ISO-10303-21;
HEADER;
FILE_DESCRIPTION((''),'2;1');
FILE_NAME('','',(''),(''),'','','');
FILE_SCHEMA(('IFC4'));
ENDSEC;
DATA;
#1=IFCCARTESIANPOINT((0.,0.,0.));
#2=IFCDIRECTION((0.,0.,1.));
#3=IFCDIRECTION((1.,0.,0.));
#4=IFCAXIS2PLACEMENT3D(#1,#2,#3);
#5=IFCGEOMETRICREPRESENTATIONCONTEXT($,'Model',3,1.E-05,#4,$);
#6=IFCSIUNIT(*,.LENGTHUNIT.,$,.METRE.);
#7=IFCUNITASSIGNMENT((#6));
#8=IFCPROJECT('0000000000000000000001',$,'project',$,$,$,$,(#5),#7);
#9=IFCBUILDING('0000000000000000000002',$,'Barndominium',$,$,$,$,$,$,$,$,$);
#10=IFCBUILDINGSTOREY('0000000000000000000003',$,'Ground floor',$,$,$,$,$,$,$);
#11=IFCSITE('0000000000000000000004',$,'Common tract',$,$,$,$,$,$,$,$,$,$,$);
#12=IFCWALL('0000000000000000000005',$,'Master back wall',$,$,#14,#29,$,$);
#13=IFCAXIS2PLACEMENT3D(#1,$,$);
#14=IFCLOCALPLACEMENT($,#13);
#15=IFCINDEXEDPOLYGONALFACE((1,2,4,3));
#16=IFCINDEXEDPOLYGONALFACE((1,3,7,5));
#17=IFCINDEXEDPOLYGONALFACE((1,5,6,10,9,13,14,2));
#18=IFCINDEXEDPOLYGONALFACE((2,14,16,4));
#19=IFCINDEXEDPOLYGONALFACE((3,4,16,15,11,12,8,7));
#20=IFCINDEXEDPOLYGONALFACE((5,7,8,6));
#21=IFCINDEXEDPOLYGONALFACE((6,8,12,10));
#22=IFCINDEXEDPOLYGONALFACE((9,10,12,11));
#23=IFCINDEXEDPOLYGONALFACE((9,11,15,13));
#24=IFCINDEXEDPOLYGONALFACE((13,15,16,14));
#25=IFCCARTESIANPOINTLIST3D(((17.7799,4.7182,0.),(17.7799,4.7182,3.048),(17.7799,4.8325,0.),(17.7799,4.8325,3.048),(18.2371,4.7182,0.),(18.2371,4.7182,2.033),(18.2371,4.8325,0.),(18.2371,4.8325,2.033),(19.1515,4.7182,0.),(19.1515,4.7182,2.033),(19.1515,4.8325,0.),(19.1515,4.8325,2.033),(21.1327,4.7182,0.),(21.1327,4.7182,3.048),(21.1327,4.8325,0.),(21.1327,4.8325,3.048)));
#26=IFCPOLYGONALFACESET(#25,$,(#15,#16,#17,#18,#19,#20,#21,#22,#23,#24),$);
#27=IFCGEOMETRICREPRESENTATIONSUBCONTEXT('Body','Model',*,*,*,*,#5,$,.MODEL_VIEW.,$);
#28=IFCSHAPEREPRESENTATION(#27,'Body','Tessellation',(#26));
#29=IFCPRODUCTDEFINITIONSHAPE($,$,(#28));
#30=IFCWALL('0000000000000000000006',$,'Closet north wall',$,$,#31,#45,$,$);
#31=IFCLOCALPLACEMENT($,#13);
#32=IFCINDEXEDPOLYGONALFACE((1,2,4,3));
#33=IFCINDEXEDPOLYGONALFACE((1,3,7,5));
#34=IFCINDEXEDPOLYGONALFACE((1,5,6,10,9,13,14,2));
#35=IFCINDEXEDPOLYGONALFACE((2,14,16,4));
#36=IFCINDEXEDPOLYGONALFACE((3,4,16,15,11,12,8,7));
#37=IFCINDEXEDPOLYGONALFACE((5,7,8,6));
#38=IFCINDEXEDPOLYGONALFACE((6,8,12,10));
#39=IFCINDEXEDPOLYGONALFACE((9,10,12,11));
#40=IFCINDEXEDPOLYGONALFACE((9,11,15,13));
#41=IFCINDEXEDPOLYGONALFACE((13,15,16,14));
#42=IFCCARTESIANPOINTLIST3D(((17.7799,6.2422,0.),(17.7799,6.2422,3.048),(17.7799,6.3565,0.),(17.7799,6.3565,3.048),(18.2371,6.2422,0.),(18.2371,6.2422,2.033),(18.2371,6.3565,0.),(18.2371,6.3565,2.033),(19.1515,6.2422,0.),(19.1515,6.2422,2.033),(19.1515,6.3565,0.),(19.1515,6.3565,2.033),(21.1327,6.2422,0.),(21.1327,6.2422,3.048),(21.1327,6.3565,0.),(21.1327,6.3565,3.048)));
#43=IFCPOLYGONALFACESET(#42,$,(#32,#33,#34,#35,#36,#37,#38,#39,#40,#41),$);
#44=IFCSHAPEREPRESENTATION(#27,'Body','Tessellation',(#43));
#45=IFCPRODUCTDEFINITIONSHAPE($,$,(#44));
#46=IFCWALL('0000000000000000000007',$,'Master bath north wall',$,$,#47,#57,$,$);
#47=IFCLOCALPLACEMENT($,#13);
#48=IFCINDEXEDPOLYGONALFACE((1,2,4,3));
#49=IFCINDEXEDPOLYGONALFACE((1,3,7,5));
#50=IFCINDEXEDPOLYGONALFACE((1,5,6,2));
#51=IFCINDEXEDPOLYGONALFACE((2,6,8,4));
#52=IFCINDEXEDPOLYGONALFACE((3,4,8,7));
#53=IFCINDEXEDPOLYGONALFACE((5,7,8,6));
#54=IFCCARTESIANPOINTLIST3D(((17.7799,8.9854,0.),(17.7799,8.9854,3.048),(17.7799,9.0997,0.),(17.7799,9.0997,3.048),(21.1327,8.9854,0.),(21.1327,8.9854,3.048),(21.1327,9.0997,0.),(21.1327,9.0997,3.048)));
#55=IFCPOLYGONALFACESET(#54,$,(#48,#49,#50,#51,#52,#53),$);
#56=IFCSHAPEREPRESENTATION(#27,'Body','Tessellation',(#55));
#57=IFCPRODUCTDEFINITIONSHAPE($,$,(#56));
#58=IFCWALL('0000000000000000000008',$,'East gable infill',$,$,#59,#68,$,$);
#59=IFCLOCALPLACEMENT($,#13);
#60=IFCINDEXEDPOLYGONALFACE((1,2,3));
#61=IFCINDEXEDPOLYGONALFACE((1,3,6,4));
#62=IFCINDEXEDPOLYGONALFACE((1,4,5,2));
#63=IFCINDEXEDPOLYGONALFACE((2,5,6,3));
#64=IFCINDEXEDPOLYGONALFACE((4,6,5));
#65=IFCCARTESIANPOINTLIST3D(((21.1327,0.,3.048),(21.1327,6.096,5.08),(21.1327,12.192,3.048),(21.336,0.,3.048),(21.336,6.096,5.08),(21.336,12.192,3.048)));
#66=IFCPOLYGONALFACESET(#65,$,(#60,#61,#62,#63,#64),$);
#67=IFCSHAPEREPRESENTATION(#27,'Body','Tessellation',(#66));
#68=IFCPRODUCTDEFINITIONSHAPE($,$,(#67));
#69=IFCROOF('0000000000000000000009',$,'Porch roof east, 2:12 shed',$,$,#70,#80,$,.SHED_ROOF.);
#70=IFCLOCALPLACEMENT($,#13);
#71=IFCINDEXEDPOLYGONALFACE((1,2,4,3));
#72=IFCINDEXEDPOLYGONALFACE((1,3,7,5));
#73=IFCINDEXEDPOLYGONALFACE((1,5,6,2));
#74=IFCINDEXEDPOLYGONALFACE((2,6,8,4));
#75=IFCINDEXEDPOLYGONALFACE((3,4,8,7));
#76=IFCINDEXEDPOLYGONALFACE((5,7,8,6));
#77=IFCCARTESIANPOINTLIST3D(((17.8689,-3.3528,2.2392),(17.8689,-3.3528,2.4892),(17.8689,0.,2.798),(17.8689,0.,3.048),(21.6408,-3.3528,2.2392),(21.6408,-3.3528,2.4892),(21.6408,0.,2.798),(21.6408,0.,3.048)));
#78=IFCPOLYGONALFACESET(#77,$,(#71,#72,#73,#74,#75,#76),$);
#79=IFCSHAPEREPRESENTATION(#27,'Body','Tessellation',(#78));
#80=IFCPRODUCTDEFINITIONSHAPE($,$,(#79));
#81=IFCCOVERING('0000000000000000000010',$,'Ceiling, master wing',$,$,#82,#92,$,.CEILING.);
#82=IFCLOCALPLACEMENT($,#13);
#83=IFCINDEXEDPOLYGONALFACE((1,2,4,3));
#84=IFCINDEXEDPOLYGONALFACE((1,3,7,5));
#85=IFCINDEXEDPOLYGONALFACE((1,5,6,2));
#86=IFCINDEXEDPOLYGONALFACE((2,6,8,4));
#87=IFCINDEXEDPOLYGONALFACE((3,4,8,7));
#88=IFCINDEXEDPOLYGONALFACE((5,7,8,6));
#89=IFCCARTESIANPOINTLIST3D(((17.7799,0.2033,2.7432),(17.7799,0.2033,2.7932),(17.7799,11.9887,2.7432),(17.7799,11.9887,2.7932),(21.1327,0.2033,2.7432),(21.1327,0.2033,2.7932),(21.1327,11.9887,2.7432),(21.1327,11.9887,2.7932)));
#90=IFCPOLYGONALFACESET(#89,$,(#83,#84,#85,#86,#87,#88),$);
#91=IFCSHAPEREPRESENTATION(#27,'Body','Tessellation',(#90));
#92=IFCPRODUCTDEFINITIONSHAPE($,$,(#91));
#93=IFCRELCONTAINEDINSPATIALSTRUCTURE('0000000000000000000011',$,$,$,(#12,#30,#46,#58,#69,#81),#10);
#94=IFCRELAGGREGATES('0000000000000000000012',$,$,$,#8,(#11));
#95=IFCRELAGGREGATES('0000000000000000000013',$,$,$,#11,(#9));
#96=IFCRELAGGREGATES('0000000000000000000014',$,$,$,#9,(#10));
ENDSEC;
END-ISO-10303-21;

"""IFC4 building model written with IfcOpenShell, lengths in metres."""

from ifc_helpers import new_model, si_unit, frame, origin_with_axes, place, context, subcontext, project, spatial, polyline, indexed_curve, rectangle, outline, extrude, element, save


model = new_model("IFC4")

# Units and contexts
model_context = context("Model", 3, precision=1e-05, world=origin_with_axes())
body_context = subcontext(model_context, "Body", "Model", "MODEL_VIEW")
ifc_project = project(units=[si_unit("LENGTHUNIT", "METRE")], contexts=[model_context])

# Site, building, storey
site = spatial("IfcSite", under=ifc_project, Name="Common tract")
building = spatial("IfcBuilding", under=site, Name="Barndominium")
storey = spatial("IfcBuildingStorey", under=building, Name="Ground floor")

# Walls, openings
wall_1_placement = place(None, frame((17.7799, 4.7182, 0.0), z_axis=(0.0, 0.0, 1.0), x_axis=(1.0, 0.0, 0.0)))
wall_1 = element("IfcWall", 1, at=wall_1_placement, inside=storey, Name="Master back wall", context=body_context, shape_type="SweptSolid", body=[
    extrude(outline(indexed_curve([(0.0, 0.0), (0.0, 0.1143), (3.3528, 0.1143), (3.3528, 0.0), (0.0, 0.0)], self_intersect=False)), origin_with_axes(), (0.0, 0.0, 1.0), 3.048),
])
opening_1_placement = place(wall_1_placement, frame((0.9144, 0.0572, 0.0), z_axis=(0.0, 0.0, 1.0), x_axis=(1.0, 0.0, 0.0)))
element("IfcOpeningElement", 2, at=opening_1_placement, cuts=wall_1, context=body_context, shape_type="SweptSolid", body=[
    extrude(rectangle(XDim=0.9144, YDim=0.3033), origin_with_axes(), (0.0, 0.0, 1.0), 2.033),
])
wall_2_placement = place(None, frame((17.7799, 6.2422, 0.0), z_axis=(0.0, 0.0, 1.0), x_axis=(1.0, 0.0, 0.0)))
wall_2 = element("IfcWall", 3, at=wall_2_placement, inside=storey, Name="Closet north wall", context=body_context, shape_type="SweptSolid", body=[
    extrude(outline(indexed_curve([(0.0, 0.0), (0.0, 0.1143), (3.3528, 0.1143), (3.3528, 0.0), (0.0, 0.0)], self_intersect=False)), origin_with_axes(), (0.0, 0.0, 1.0), 3.048),
])
opening_2_placement = place(wall_2_placement, frame((0.9144, 0.0572, 0.0), z_axis=(0.0, 0.0, 1.0), x_axis=(1.0, 0.0, 0.0)))
element("IfcOpeningElement", 4, at=opening_2_placement, cuts=wall_2, context=body_context, shape_type="SweptSolid", body=[
    extrude(rectangle(XDim=0.9144, YDim=0.3033), origin_with_axes(), (0.0, 0.0, 1.0), 2.033),
])

# Walls
wall_3_placement = place(None, frame((17.7799, 8.9854, 0.0), z_axis=(0.0, 0.0, 1.0), x_axis=(1.0, 0.0, 0.0)))
element("IfcWall", 5, at=wall_3_placement, inside=storey, Name="Master bath north wall", context=body_context, shape_type="SweptSolid", body=[
    extrude(outline(indexed_curve([(0.0, 0.0), (0.0, 0.1143), (3.3528, 0.1143), (3.3528, 0.0), (0.0, 0.0)], self_intersect=False)), origin_with_axes(), (0.0, 0.0, 1.0), 3.048),
])
wall_4_placement = place(None, frame((21.1327, 0.0, 0.0), z_axis=(1.0, 0.0, 0.0), x_axis=(0.0, 1.0, 0.0)))
element("IfcWall", 6, at=wall_4_placement, inside=storey, Name="East gable infill", context=body_context, shape_type="SweptSolid", body=[
    extrude(outline(polyline([(0.0, 3.048), (12.192, 3.048), (6.096, 5.08), (0.0, 3.048)])), origin_with_axes(), (0.0, 0.0, 1.0), 0.2033),
])

# Roof
roof_placement = place(None, frame((17.8689, 0.0, 0.0), z_axis=(1.0, 0.0, 0.0), x_axis=(0.0, 1.0, 0.0)))
element("IfcRoof", 7, at=roof_placement, inside=storey, Name="Porch roof east, 2:12 shed", PredefinedType="SHED_ROOF", context=body_context, shape_type="SweptSolid", body=[
    extrude(outline(polyline([(0.0, 2.798), (-3.3528, 2.2392), (-3.3528, 2.4892), (0.0, 3.048), (0.0, 2.798)])), origin_with_axes(), (0.0, 0.0, 1.0), 3.7719),
])

# Covering
covering_placement = place(None, frame((19.4563, 6.096, 2.7432), z_axis=(0.0, 0.0, 1.0), x_axis=(1.0, 0.0, 0.0)))
element("IfcCovering", 8, at=covering_placement, inside=storey, Name="Ceiling, master wing", PredefinedType="CEILING", context=body_context, shape_type="SweptSolid", body=[
    extrude(rectangle(XDim=3.3528, YDim=11.7854), origin_with_axes(), (0.0, 0.0, 1.0), 0.05),
])

save(model, "model.ifc")
